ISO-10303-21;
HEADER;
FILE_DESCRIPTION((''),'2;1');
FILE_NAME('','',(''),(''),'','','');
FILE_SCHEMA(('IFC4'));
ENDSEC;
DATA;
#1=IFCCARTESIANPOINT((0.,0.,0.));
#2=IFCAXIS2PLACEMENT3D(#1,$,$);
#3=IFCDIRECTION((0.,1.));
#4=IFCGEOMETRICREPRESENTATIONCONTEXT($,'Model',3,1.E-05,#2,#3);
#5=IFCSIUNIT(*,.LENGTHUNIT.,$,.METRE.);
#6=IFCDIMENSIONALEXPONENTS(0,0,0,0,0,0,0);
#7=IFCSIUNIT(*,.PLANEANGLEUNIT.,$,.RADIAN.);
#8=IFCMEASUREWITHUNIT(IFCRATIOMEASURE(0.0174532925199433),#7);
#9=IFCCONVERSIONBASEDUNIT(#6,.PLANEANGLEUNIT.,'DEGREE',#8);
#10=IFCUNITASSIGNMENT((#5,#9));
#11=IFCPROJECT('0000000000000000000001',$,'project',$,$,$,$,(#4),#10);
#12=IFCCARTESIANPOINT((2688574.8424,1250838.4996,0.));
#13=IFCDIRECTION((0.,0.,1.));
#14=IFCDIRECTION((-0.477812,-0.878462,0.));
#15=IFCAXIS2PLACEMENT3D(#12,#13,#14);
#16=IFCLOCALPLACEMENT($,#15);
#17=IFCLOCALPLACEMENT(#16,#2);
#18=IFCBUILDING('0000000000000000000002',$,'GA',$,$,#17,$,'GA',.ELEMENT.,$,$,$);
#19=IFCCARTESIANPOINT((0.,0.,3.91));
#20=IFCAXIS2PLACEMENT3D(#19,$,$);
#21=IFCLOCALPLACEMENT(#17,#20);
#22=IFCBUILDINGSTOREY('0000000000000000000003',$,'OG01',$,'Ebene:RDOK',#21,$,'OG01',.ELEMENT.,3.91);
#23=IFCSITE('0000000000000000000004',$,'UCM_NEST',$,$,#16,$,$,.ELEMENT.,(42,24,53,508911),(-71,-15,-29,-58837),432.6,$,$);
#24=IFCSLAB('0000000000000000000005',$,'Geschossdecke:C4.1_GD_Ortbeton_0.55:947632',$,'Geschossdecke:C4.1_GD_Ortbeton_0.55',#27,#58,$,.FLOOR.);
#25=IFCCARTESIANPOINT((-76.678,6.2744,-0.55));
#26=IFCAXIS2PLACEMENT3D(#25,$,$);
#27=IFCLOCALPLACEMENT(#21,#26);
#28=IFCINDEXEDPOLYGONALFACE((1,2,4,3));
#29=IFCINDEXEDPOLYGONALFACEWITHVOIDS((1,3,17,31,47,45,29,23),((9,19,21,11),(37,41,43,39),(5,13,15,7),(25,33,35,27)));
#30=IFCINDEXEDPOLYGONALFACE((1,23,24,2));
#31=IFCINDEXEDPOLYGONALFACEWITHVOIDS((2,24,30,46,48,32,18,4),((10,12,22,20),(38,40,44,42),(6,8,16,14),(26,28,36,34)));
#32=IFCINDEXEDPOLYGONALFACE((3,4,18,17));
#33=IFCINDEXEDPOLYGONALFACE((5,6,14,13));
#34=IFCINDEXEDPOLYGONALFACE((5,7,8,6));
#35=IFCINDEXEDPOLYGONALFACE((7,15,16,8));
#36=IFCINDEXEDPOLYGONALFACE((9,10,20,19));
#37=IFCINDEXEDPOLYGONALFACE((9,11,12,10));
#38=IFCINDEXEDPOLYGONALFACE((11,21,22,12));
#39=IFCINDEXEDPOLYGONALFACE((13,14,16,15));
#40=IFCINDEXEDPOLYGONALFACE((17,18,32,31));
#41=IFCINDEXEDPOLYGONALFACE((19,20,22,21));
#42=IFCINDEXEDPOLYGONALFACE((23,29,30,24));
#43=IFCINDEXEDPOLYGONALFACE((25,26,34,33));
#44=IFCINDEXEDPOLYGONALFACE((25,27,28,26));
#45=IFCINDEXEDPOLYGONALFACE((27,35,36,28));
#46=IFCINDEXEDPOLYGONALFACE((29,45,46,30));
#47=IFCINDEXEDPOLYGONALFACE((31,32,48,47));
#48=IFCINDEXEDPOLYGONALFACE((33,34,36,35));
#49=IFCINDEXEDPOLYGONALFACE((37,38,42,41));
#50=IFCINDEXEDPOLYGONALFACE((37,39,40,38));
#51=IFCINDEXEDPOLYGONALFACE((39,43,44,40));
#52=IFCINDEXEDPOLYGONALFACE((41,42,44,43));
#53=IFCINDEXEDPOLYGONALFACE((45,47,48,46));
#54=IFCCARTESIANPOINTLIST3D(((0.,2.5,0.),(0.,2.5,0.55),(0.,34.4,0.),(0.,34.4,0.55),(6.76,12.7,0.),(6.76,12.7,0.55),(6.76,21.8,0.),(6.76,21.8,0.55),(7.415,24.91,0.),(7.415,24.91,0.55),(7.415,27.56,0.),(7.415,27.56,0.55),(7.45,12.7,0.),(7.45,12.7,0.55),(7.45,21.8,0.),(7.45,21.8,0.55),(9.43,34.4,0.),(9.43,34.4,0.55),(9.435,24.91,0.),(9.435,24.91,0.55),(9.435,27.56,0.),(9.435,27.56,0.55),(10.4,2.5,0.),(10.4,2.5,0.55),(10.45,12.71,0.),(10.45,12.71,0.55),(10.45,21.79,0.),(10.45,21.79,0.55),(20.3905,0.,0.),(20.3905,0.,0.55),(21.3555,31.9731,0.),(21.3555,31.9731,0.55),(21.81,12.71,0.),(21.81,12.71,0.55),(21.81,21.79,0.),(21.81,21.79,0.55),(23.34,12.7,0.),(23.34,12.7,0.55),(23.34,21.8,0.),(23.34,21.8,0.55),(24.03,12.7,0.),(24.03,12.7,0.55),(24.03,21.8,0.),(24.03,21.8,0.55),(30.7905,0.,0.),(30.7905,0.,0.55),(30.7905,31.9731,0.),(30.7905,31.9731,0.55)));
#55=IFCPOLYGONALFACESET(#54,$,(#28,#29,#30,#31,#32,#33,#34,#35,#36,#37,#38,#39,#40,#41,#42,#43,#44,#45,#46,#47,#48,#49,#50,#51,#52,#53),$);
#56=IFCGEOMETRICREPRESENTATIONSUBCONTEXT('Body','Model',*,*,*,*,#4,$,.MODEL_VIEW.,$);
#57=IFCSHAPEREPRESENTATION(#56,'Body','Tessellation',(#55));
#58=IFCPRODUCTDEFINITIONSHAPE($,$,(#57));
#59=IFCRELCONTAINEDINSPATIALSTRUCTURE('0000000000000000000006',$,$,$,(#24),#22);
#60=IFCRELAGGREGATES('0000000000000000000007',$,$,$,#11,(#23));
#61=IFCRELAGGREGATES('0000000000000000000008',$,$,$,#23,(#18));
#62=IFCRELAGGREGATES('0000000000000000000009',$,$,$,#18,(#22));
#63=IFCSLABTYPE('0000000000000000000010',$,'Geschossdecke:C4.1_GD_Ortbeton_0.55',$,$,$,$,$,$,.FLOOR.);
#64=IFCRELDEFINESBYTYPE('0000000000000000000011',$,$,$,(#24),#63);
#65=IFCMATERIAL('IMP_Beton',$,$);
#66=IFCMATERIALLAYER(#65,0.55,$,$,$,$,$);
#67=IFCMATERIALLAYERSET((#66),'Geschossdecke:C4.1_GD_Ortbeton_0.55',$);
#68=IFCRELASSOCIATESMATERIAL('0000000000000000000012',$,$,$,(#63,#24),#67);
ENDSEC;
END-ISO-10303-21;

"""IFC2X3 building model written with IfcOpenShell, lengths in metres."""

from ifc_helpers import new_model, entity, si_unit, converted_unit, direction, frame, origin, origin_2d_with_axis, place, context, subcontext, project, spatial, polyline, rectangle, outline, extrude, material, layer, layer_set, layer_usage, type_object, element, save


model = new_model("IFC2X3")

# Units and contexts
model_context = context("Model", 3, precision=1e-05, world=origin(), true_north=direction((0.0, 1.0)))
body_context = subcontext(model_context, "Body", "Model", "MODEL_VIEW")
ifc_project = project(units=[si_unit("LENGTHUNIT", "METRE"), converted_unit("PLANEANGLEUNIT", "DEGREE", entity("IfcRatioMeasure", 0.0174532925199433), si_unit("PLANEANGLEUNIT", "RADIAN"), dimensions=[0, 0, 0, 0, 0, 0, 0])], contexts=[model_context])

# Site, building, storey
site_placement = place(None, frame((2688574.8424, 1250838.4996, 0.0), z_axis=(0.0, 0.0, 1.0), x_axis=(-0.477812, -0.878462, 0.0)))
site = spatial("IfcSite", under=ifc_project, at=site_placement, Name="UCM_NEST", CompositionType="ELEMENT", RefLatitude=(42, 24, 53, 508911), RefLongitude=(-71, -15, -29, -58837), RefElevation=432.6)
building_placement = place(site_placement, origin())
building = spatial("IfcBuilding", under=site, at=building_placement, Name="GA", LongName="GA", CompositionType="ELEMENT")
storey_placement = place(building_placement, frame((0.0, 0.0, 3.91)))
storey = spatial("IfcBuildingStorey", under=building, at=storey_placement, Name="OG01", ObjectType="Ebene:RDOK", LongName="OG01", CompositionType="ELEMENT", Elevation=3.91)

# Slab, openings
ifc_material_1 = material(Name="IMP_Beton")
ifc_layer_1 = layer(ifc_material_1, 0.55)
ifc_layer_set_1 = layer_set([ifc_layer_1], Name="Geschossdecke:C4.1_GD_Ortbeton_0.55")
ifc_layer_usage_1 = layer_usage(ifc_layer_set_1, "AXIS3", "POSITIVE", 0.0)
slab_type_1 = type_object("IfcSlabType", Name="Geschossdecke:C4.1_GD_Ortbeton_0.55", PredefinedType="FLOOR", material=ifc_layer_set_1)
slab_1_placement = place(storey_placement, frame((-76.678, 6.2744, -0.55)))
slab_1 = element("IfcSlab", 1, at=slab_1_placement, inside=storey, type_object=slab_type_1, material=ifc_layer_usage_1, Name="Geschossdecke:C4.1_GD_Ortbeton_0.55:947632", ObjectType="Geschossdecke:C4.1_GD_Ortbeton_0.55", PredefinedType="FLOOR", context=body_context, shape_type="SweptSolid", body=[
    extrude(outline(polyline([(15.3952, 17.2), (5.9652, 17.2), (-5.9602, 14.7731), (-15.3952, 14.7731), (-15.3952, -17.1969), (-15.3952, -17.2), (-4.9952, -17.2), (4.9952, -14.7), (15.3952, -14.7), (15.3952, 17.2)])), frame((15.3952, 17.2, 0.55), z_axis=(0.0, 0.0, -1.0), x_axis=(-1.0, 0.0, 0.0)), (0.0, 0.0, 1.0), 0.55),
])
opening_1_placement = place(slab_1_placement, frame((7.105, 17.25, 0.55)))
element("IfcOpeningElement", 2, at=opening_1_placement, cuts=slab_1, ObjectType="Opening", context=body_context, shape_type="SweptSolid", body=[
    extrude(rectangle(XDim=0.69, YDim=9.1, at=origin_2d_with_axis()), frame((0.0, 0.0, 0.0), z_axis=(0.0, 0.0, -1.0), x_axis=(1.0, 0.0, 0.0)), (0.0, 0.0, 1.0), 0.55),
])
opening_2_placement = place(slab_1_placement, frame((23.685, 17.25, 0.55)))
element("IfcOpeningElement", 3, at=opening_2_placement, cuts=slab_1, ObjectType="Opening", context=body_context, shape_type="SweptSolid", body=[
    extrude(rectangle(XDim=0.69, YDim=9.1, at=origin_2d_with_axis()), frame((0.0, 0.0, 0.0), z_axis=(0.0, 0.0, -1.0), x_axis=(-1.0, 0.0, 0.0)), (0.0, 0.0, 1.0), 0.55),
])
opening_3_placement = place(slab_1_placement, frame((16.13, 17.25, 0.55)))
element("IfcOpeningElement", 4, at=opening_3_placement, cuts=slab_1, ObjectType="Opening", context=body_context, shape_type="SweptSolid", body=[
    extrude(rectangle(XDim=9.08, YDim=11.36, at=origin_2d_with_axis()), frame((0.0, 0.0, 0.0), z_axis=(0.0, 0.0, -1.0), x_axis=(0.0, -1.0, 0.0)), (0.0, 0.0, 1.0), 0.55),
])
opening_4_placement = place(slab_1_placement, frame((8.425, 26.235, 0.55)))
element("IfcOpeningElement", 5, at=opening_4_placement, cuts=slab_1, ObjectType="Opening", context=body_context, shape_type="SweptSolid", body=[
    extrude(rectangle(XDim=2.65, YDim=2.02, at=origin_2d_with_axis()), frame((0.0, 0.0, 0.0), z_axis=(0.0, 0.0, 1.0), x_axis=(0.0, 1.0, 0.0)), (0.0, 0.0, -1.0), 0.55),
])

save(model, "model.ifc")
